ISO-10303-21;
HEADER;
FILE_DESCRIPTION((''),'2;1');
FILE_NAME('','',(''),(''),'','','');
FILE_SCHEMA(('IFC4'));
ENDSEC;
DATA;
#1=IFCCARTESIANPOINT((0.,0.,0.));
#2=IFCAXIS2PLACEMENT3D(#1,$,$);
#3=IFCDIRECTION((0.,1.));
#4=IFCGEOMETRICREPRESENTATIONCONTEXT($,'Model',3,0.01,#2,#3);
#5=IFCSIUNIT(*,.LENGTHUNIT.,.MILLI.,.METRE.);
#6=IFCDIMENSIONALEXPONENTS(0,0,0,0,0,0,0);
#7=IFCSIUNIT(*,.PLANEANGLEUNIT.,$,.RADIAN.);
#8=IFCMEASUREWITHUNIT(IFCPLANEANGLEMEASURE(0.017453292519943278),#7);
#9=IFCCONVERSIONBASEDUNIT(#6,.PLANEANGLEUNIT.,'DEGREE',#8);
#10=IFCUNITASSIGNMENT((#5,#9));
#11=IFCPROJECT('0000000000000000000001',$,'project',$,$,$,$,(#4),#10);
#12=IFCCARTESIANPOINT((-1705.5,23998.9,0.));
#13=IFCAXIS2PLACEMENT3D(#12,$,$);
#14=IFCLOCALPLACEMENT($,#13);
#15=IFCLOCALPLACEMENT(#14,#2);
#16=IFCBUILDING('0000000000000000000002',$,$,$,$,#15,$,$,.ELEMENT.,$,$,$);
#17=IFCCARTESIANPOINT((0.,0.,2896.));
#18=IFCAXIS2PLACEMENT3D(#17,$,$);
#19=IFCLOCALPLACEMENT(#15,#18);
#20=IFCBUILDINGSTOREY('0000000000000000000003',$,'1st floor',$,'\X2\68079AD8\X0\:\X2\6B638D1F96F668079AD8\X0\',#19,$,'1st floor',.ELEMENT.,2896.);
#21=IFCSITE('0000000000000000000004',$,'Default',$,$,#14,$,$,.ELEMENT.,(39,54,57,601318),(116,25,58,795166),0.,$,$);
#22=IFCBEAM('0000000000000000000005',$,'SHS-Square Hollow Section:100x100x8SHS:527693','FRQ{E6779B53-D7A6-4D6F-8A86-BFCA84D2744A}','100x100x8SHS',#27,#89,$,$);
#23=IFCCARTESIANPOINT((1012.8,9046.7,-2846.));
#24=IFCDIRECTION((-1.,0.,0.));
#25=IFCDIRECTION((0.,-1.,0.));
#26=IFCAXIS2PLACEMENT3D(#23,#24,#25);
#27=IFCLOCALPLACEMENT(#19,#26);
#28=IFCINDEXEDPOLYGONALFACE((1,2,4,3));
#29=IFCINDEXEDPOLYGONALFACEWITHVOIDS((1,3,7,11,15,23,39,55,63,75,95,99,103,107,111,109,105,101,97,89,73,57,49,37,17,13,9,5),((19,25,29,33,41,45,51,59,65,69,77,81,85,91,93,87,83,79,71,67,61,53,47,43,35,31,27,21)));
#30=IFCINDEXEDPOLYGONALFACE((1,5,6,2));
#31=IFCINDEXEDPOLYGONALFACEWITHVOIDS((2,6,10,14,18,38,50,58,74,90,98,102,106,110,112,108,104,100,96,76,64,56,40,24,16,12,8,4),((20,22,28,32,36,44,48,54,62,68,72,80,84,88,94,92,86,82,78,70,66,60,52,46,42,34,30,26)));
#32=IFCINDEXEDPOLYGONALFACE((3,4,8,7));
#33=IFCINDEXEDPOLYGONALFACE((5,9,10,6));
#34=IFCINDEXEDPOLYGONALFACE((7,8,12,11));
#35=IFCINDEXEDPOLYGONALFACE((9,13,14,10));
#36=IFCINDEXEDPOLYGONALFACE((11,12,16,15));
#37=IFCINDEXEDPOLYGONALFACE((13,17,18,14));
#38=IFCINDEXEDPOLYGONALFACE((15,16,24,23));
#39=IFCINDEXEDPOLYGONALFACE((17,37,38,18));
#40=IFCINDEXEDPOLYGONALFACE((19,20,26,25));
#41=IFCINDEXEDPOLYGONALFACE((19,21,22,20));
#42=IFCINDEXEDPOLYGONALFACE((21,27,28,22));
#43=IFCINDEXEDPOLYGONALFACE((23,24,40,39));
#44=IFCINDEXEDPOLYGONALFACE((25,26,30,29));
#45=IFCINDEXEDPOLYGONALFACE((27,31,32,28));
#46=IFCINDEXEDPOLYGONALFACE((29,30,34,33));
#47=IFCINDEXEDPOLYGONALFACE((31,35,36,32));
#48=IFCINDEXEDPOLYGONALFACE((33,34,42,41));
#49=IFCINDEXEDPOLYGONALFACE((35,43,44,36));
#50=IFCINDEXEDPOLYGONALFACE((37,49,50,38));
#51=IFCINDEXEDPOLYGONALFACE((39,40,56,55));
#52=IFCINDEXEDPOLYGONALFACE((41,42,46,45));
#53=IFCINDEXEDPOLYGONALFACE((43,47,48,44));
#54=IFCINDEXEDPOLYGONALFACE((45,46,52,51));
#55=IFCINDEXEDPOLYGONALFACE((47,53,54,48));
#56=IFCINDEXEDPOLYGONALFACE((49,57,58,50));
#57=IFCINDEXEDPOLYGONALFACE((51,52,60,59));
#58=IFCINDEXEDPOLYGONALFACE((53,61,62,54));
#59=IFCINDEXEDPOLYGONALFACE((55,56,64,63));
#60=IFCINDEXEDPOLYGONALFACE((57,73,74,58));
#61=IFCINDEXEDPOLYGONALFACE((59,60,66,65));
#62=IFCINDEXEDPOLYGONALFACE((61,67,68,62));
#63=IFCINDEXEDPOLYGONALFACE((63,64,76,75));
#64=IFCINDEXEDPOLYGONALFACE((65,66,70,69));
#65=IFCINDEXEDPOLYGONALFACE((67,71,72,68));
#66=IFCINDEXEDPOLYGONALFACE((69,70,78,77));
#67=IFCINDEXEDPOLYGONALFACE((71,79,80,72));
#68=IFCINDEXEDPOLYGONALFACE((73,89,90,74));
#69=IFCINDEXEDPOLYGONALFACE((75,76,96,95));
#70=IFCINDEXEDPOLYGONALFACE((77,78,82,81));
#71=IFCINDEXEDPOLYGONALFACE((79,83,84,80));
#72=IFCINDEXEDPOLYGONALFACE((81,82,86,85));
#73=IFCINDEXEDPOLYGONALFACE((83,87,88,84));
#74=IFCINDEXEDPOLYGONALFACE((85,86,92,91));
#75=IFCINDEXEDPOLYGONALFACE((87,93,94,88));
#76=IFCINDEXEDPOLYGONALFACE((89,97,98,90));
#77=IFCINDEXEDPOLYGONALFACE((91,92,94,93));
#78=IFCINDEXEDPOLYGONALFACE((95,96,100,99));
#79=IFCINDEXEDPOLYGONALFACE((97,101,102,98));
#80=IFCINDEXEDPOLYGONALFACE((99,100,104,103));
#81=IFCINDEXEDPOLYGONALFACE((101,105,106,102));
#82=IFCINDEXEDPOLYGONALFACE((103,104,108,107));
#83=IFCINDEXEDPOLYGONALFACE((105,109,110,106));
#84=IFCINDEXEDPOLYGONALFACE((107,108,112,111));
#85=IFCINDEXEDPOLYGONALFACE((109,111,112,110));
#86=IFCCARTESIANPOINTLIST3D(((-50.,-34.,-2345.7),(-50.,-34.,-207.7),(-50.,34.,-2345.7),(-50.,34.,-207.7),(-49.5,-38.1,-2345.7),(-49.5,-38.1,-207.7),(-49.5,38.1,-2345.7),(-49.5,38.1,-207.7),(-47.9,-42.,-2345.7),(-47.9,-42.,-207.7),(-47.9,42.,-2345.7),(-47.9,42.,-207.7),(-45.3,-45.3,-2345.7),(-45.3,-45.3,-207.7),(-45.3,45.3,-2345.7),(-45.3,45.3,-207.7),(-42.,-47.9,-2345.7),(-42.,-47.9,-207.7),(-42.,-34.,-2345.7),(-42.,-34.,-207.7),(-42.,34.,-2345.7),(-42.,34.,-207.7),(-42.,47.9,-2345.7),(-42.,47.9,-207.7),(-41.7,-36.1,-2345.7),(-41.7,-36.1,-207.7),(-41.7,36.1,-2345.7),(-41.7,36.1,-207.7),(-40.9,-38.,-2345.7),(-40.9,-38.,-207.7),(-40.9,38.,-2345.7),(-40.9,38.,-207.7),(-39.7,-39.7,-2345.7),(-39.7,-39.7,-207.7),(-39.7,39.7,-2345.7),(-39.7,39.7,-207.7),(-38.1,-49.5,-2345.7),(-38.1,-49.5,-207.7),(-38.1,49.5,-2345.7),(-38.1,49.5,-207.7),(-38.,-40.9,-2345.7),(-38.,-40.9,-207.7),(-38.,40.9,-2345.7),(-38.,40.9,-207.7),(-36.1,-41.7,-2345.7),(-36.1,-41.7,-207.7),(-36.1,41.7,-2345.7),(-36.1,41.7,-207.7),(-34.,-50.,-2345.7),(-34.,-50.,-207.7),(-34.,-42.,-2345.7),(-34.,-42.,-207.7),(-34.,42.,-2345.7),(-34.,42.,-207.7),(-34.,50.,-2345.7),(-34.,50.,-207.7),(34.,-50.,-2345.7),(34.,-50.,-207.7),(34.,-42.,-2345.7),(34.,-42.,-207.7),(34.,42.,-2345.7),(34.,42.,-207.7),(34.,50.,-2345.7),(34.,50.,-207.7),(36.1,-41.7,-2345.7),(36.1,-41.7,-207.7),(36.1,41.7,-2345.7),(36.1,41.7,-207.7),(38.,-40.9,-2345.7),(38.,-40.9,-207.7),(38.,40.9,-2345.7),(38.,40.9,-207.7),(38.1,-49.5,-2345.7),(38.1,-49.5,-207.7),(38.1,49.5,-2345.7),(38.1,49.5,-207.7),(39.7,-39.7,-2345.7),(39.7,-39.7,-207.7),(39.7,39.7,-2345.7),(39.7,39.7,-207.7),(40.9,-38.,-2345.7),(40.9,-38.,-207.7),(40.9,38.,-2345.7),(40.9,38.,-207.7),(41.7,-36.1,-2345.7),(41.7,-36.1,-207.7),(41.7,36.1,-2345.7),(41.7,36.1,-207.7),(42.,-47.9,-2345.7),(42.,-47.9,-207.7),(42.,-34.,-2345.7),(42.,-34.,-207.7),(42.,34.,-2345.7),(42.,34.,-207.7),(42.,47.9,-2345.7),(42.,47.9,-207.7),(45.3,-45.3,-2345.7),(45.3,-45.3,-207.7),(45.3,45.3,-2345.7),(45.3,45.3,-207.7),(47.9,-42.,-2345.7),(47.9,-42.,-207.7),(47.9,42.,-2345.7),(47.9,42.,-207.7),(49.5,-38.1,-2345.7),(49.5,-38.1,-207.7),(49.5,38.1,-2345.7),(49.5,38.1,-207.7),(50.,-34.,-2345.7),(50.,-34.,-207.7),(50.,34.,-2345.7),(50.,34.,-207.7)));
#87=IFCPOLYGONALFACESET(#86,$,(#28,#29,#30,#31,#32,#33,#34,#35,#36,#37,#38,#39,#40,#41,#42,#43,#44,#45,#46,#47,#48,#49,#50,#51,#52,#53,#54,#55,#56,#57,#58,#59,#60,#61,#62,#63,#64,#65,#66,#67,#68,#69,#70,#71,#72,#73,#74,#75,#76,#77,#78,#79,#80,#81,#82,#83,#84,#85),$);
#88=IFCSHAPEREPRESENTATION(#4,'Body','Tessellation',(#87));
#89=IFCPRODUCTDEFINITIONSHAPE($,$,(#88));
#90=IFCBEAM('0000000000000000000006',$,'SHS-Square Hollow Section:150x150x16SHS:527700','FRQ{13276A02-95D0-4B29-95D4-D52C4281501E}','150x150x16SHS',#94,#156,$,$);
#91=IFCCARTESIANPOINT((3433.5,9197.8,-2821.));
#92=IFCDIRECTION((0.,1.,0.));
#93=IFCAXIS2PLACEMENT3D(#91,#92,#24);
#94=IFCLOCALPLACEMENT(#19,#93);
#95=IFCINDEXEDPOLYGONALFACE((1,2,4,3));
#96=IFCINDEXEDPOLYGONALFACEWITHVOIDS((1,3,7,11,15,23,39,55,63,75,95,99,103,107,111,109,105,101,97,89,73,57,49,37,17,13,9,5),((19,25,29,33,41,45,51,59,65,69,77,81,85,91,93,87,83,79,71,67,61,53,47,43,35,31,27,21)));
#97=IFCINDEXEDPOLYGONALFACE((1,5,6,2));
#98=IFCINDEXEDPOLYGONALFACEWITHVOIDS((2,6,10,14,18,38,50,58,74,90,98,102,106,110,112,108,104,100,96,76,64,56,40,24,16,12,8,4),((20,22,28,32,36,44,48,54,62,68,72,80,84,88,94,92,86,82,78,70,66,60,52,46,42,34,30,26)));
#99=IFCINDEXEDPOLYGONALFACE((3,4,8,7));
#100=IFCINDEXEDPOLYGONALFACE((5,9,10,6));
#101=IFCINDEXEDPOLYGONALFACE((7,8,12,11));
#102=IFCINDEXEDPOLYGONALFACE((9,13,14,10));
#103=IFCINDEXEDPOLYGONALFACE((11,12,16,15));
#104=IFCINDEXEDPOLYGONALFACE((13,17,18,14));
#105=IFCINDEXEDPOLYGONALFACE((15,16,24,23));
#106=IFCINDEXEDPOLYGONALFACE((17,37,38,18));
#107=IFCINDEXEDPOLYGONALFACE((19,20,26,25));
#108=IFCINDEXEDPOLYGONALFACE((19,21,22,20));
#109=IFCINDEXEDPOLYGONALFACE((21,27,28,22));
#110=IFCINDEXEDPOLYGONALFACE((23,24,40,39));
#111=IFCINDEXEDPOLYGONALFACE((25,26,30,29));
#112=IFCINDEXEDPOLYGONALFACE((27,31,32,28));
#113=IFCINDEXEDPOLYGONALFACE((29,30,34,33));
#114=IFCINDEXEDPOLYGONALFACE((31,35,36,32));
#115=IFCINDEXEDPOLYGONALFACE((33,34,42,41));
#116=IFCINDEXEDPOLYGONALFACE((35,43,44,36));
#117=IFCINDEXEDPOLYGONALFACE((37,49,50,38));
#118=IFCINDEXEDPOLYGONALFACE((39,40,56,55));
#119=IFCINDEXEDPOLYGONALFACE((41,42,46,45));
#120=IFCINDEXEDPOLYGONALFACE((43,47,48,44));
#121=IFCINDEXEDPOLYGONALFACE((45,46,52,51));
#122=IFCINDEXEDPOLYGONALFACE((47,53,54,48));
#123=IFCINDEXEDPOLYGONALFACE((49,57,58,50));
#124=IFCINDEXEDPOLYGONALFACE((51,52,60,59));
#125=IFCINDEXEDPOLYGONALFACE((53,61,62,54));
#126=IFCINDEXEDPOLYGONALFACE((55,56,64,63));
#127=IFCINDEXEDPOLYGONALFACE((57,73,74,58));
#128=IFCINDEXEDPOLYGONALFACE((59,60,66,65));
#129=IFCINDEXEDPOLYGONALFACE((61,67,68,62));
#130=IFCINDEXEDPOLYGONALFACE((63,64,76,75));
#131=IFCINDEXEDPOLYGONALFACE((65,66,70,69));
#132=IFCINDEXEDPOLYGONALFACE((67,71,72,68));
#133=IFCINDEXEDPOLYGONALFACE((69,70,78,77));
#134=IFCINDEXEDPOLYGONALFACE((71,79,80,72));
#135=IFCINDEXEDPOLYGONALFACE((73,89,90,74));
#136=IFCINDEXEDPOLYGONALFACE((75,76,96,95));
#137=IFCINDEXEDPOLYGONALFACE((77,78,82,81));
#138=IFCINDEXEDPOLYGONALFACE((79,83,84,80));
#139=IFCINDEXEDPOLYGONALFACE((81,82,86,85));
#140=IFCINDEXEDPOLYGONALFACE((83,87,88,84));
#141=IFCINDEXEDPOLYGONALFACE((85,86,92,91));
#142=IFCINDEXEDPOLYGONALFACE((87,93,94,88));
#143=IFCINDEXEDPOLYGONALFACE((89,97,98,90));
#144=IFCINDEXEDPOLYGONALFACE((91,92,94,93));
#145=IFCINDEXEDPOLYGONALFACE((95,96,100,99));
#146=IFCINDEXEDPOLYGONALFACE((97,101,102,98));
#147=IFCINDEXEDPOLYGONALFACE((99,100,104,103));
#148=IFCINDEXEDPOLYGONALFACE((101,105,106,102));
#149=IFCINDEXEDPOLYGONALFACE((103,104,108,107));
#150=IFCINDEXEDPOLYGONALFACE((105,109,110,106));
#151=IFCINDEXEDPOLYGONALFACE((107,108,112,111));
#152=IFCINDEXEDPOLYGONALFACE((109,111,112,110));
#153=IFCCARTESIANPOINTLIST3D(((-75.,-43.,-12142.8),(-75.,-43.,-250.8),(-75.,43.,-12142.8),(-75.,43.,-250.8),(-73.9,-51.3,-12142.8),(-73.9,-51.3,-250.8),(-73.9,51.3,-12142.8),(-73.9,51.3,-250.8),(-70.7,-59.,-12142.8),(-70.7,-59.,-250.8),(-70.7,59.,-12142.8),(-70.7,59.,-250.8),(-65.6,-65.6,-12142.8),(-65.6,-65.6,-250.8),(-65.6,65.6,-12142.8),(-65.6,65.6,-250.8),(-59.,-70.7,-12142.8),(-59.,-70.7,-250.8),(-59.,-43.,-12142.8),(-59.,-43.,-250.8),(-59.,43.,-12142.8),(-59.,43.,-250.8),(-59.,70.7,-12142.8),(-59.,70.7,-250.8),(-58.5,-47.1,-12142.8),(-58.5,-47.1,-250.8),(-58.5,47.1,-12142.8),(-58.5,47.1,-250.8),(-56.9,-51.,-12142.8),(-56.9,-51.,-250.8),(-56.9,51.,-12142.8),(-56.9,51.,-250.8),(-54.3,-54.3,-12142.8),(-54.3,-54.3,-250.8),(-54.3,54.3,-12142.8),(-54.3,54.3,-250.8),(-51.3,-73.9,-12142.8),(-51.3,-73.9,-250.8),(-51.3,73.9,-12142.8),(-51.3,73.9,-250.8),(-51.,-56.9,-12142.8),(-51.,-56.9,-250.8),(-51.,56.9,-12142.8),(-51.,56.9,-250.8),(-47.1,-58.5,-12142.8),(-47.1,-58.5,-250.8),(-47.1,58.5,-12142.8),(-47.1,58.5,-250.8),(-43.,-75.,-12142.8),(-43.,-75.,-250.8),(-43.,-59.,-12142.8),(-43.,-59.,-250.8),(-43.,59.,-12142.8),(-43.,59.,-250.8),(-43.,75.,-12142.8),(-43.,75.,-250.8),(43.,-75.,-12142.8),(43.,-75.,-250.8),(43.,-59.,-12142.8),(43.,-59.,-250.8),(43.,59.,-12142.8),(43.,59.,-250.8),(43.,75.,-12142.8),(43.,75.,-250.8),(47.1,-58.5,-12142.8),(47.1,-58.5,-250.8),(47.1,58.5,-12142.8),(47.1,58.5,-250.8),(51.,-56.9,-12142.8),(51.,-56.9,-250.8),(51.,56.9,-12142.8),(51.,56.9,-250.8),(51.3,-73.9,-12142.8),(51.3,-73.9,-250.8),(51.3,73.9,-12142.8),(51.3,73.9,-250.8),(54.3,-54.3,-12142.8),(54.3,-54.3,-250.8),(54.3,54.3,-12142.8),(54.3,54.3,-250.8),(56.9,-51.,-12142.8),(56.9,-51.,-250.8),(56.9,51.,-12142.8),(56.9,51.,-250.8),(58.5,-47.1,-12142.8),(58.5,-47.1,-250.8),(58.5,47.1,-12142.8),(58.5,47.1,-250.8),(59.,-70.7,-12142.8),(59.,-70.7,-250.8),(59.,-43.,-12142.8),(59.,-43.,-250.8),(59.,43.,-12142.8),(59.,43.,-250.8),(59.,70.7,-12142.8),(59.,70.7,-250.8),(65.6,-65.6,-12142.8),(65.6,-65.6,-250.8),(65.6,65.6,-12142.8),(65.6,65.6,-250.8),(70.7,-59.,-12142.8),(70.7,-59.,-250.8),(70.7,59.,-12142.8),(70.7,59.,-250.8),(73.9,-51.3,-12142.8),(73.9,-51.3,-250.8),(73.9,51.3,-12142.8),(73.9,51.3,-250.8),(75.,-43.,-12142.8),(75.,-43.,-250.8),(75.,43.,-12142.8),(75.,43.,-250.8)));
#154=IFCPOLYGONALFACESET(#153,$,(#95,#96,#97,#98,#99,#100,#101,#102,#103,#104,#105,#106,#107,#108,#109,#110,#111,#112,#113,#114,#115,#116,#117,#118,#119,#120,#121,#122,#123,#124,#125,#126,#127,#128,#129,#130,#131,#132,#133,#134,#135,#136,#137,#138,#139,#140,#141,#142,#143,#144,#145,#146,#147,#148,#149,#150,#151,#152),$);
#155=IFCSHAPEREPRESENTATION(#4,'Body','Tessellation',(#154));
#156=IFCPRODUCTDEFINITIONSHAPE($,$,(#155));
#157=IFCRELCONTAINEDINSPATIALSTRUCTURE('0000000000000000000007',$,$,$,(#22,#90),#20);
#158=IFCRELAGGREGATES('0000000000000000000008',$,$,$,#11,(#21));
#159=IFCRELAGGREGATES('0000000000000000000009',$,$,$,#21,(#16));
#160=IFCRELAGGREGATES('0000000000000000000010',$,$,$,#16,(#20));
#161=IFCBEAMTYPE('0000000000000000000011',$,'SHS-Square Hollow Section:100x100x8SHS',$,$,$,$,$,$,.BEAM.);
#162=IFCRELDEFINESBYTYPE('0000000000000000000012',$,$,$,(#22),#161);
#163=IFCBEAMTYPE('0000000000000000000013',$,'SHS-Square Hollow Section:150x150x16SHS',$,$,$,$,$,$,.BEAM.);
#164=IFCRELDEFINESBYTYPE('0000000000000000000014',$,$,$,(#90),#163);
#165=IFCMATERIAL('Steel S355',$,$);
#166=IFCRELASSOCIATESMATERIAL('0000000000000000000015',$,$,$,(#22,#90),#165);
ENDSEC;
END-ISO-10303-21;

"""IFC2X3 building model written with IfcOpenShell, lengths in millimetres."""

from ifc_helpers import new_model, entity, si_unit, converted_unit, direction, frame, origin, origin_2d, place, context, project, spatial, hollow_rectangle, extrude, clip, halfspace, material, type_object, element, save


model = new_model("IFC2X3")

# Units and contexts
model_context = context("Model", 3, precision=0.01, world=origin(), true_north=direction((0.0, 1.0)))
ifc_project = project(units=[si_unit("LENGTHUNIT", "METRE", prefix="MILLI"), converted_unit("PLANEANGLEUNIT", "DEGREE", entity("IfcPlaneAngleMeasure", 0.017453292519943278), si_unit("PLANEANGLEUNIT", "RADIAN"), dimensions=[0, 0, 0, 0, 0, 0, 0])], contexts=[model_context])

# Site, building, storey
site_placement = place(None, frame((-1705.5, 23998.9, 0.0)))
site = spatial("IfcSite", under=ifc_project, at=site_placement, Name="Default", CompositionType="ELEMENT", RefLatitude=(39, 54, 57, 601318), RefLongitude=(116, 25, 58, 795166), RefElevation=0.0)
building_placement = place(site_placement, origin())
building = spatial("IfcBuilding", under=site, at=building_placement, CompositionType="ELEMENT")
storey_placement = place(building_placement, frame((0.0, 0.0, 2896.0)))
storey = spatial("IfcBuildingStorey", under=building, at=storey_placement, Name="1st floor", ObjectType="标高:正负零标高", LongName="1st floor", CompositionType="ELEMENT", Elevation=2896.0)

# Shared definitions
ifc_material_1 = material(Name="Steel S355")

# Beams
beam_type_1 = type_object("IfcBeamType", Name="SHS-Square Hollow Section:100x100x8SHS", PredefinedType="BEAM")
beam_1_placement = place(storey_placement, frame((1012.8, 9046.7, -2846.0), z_axis=(-1.0, 0.0, 0.0), x_axis=(0.0, -1.0, 0.0)))
element("IfcBeam", 1, at=beam_1_placement, inside=storey, type_object=beam_type_1, material=ifc_material_1, Name="SHS-Square Hollow Section:100x100x8SHS:527693", Description="FRQ{E6779B53-D7A6-4D6F-8A86-BFCA84D2744A}", ObjectType="100x100x8SHS", context=model_context, shape_type="Clipping", body=[
    clip(clip(extrude(hollow_rectangle(XDim=100.0, YDim=100.0, WallThickness=8.0, InnerFilletRadius=8.0, OuterFilletRadius=16.0, at=origin_2d()), origin(), (0.0, 0.0, -1.0), 2551.4), halfspace(frame((9046.7, -50.0, -207.7), z_axis=(0.0, 0.0, -1.0), x_axis=(-1.0, 0.0, 0.0)), True)), halfspace(frame((9046.7, -50.0, -2345.7), z_axis=(0.0, 0.0, 1.0), x_axis=(1.0, 0.0, 0.0)), True)),
])
beam_type_2 = type_object("IfcBeamType", Name="SHS-Square Hollow Section:150x150x16SHS", PredefinedType="BEAM")
beam_2_placement = place(storey_placement, frame((3433.5, 9197.8, -2821.0), z_axis=(0.0, 1.0, 0.0), x_axis=(-1.0, 0.0, 0.0)))
element("IfcBeam", 2, at=beam_2_placement, inside=storey, type_object=beam_type_2, material=ifc_material_1, Name="SHS-Square Hollow Section:150x150x16SHS:527700", Description="FRQ{13276A02-95D0-4B29-95D4-D52C4281501E}", ObjectType="150x150x16SHS", context=model_context, shape_type="Clipping", body=[
    clip(clip(extrude(hollow_rectangle(XDim=150.0, YDim=150.0, WallThickness=16.0, InnerFilletRadius=16.0, OuterFilletRadius=32.0, at=origin_2d()), origin(), (0.0, 0.0, -1.0), 12398.9), halfspace(frame((3433.5, -75.0, -12142.8), z_axis=(0.0, 0.0, 1.0), x_axis=(1.0, 0.0, 0.0)), True)), halfspace(frame((3433.5, -75.0, -250.8), z_axis=(0.0, 0.0, -1.0), x_axis=(-1.0, 0.0, 0.0)), True)),
])

save(model, "model.ifc")
